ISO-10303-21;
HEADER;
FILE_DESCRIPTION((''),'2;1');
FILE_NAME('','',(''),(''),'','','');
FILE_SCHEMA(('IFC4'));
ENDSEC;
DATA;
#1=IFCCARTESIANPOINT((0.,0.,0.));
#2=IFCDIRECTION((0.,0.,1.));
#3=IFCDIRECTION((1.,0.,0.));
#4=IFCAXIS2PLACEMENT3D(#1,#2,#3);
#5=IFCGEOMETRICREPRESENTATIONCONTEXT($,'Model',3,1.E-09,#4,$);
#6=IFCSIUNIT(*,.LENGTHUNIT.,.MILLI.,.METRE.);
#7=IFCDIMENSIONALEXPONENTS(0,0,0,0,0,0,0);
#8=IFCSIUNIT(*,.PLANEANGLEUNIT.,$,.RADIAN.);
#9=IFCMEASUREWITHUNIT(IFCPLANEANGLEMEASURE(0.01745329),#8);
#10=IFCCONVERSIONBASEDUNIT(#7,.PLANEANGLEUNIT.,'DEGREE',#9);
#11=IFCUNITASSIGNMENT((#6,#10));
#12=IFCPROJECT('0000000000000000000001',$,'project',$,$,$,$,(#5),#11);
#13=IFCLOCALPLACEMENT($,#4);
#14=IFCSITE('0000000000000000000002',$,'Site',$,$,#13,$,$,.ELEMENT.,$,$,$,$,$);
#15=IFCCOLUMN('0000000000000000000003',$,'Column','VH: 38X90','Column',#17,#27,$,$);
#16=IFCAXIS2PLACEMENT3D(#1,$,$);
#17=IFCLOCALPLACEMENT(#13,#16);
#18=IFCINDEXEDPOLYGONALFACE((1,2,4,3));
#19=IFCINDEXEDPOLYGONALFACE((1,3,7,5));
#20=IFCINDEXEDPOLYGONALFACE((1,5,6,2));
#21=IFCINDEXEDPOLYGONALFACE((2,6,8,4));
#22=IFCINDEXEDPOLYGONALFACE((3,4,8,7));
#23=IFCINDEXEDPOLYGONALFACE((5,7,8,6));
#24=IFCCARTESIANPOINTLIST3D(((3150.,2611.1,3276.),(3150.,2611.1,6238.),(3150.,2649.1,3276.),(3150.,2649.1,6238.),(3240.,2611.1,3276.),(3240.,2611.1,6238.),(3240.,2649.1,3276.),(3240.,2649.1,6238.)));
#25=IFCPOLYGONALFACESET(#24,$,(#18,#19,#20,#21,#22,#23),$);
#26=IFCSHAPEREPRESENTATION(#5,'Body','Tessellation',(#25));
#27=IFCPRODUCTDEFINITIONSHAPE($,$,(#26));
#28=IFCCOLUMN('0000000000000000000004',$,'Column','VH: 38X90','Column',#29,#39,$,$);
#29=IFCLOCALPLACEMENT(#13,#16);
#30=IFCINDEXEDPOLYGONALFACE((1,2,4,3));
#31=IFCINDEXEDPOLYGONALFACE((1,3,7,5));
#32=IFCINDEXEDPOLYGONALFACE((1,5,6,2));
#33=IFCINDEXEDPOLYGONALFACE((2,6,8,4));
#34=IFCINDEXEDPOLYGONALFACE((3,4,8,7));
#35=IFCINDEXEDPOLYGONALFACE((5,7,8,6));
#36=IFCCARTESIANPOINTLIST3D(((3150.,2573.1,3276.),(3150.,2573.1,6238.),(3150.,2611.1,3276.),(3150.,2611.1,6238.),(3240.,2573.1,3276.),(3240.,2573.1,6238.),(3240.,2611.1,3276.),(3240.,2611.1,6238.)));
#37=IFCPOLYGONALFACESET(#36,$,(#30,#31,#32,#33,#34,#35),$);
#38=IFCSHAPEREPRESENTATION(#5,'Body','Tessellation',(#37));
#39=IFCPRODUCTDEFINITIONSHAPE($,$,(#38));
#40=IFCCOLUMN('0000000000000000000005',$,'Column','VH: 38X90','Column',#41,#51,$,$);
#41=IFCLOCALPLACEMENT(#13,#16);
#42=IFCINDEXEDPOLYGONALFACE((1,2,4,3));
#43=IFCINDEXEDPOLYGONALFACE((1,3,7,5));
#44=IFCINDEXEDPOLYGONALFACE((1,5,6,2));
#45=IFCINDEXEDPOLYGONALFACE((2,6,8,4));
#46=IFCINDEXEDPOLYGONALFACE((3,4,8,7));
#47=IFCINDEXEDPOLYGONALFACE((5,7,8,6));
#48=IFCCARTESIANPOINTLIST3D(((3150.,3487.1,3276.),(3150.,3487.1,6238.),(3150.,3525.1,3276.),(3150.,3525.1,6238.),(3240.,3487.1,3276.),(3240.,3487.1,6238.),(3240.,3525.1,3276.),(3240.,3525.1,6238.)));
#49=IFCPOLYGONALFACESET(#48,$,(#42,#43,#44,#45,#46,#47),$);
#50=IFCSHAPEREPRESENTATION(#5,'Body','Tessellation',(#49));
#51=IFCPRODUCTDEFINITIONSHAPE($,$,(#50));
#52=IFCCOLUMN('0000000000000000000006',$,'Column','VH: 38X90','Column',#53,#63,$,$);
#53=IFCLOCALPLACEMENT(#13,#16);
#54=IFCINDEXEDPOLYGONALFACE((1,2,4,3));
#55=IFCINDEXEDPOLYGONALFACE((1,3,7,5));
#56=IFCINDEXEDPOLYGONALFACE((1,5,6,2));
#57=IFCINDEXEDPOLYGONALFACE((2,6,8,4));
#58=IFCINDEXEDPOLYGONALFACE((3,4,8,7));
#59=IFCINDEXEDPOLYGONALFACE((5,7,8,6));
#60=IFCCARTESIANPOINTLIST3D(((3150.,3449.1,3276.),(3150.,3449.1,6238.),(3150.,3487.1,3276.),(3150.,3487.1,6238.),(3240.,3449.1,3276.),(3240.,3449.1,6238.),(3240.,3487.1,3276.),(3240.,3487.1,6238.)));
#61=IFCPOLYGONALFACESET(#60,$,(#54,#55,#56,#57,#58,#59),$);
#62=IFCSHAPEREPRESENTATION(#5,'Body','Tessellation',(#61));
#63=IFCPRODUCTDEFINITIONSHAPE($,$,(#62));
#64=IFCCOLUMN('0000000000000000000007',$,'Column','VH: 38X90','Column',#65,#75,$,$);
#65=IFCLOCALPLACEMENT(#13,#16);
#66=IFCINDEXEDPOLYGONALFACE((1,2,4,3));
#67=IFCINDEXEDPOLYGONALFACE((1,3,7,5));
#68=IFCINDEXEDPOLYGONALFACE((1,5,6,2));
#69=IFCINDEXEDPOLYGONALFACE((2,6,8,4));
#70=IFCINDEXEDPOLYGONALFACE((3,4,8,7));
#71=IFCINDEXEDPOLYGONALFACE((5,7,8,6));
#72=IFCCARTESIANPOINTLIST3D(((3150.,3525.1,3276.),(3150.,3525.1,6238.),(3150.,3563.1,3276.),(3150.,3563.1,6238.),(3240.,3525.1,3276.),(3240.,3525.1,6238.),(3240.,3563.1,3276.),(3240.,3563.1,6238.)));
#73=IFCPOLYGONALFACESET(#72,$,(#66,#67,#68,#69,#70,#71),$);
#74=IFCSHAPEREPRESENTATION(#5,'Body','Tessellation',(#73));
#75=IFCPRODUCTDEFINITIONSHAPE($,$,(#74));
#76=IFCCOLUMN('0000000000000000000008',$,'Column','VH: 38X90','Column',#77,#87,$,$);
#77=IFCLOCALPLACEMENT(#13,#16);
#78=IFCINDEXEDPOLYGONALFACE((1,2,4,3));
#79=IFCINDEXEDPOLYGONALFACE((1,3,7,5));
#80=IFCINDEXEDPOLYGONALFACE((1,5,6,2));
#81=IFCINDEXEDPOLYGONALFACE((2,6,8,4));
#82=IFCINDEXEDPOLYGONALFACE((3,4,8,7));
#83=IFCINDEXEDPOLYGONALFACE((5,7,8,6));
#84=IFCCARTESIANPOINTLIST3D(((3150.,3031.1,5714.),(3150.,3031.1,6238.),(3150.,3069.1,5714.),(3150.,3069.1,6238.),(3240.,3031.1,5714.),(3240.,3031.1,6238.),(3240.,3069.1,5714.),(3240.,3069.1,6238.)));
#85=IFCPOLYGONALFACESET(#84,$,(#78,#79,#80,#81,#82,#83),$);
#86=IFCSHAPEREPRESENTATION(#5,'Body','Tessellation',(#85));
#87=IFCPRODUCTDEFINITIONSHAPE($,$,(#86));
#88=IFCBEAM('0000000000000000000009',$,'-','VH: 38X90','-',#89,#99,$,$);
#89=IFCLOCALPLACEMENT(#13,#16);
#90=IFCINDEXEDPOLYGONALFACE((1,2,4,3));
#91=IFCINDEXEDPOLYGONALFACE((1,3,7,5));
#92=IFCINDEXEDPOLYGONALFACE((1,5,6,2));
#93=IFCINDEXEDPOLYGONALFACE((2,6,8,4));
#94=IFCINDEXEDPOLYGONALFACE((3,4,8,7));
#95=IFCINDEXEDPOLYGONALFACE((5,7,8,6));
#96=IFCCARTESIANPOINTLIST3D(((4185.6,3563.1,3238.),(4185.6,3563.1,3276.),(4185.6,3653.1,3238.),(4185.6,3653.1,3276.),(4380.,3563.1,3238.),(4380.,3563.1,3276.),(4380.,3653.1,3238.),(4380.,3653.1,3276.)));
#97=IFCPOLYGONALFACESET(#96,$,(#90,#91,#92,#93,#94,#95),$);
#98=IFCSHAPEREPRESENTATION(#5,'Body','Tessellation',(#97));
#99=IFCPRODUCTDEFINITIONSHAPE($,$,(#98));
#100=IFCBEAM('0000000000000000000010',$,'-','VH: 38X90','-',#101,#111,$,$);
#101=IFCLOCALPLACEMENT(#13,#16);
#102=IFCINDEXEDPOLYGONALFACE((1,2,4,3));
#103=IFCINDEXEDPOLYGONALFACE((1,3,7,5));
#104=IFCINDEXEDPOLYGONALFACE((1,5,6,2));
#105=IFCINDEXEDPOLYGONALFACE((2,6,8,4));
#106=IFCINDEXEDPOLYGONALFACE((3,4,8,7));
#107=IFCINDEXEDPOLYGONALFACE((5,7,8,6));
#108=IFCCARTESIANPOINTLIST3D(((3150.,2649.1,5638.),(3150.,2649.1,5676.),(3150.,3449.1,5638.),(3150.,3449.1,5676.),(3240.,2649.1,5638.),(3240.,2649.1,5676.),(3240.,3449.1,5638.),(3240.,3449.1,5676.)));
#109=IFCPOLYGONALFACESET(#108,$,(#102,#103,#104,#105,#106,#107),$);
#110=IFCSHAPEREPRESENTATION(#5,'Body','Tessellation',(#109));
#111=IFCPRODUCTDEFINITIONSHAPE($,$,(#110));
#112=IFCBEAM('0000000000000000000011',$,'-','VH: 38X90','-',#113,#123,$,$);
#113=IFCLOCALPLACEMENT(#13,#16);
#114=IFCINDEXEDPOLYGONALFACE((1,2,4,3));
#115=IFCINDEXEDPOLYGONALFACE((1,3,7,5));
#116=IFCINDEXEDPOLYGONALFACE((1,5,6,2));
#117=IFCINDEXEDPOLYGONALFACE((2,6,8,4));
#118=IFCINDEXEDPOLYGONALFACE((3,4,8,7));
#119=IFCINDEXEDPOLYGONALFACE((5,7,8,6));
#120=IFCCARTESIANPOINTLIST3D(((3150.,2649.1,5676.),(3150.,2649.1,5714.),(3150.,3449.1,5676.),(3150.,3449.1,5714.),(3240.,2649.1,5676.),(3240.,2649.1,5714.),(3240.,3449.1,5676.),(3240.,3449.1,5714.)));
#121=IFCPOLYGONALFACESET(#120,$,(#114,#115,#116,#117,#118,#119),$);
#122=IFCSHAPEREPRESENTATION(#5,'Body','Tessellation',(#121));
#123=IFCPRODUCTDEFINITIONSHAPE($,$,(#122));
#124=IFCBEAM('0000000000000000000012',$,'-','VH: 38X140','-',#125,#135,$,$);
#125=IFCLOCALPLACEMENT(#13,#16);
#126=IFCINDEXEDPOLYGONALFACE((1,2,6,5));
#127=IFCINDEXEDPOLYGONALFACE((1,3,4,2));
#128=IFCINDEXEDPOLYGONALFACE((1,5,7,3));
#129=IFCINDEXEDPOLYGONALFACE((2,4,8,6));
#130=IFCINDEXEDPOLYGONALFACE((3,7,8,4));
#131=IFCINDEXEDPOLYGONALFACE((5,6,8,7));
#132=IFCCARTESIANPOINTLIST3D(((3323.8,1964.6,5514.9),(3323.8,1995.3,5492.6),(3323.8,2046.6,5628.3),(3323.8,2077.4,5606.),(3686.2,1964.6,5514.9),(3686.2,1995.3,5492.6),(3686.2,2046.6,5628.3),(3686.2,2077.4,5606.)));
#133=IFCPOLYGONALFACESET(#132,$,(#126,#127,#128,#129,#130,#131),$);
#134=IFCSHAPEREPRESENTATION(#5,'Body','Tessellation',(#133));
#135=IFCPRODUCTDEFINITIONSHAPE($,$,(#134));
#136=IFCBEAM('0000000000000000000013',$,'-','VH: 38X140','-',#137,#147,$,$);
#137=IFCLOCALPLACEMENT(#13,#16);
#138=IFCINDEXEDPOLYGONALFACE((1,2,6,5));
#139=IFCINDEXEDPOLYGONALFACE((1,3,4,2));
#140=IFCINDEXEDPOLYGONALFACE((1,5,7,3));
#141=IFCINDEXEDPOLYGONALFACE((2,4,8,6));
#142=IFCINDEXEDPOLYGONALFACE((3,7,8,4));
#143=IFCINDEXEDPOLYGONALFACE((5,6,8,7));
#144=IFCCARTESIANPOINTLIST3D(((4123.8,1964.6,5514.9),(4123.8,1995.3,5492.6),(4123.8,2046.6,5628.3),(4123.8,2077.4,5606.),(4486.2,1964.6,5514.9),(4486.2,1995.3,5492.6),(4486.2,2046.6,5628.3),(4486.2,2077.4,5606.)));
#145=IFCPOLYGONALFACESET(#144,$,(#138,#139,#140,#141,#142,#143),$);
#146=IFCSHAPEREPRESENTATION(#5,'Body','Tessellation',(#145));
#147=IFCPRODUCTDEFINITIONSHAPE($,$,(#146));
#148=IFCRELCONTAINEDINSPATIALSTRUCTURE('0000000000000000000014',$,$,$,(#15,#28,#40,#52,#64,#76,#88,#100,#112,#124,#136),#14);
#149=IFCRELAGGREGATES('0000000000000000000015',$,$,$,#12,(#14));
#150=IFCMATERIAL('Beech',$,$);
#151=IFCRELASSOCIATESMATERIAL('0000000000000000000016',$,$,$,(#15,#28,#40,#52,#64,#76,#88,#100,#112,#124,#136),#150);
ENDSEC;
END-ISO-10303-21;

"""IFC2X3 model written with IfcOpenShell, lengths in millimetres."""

from ifc_helpers import new_model, entity, si_unit, converted_unit, frame, origin, origin_with_axes, origin_2d, place, context, project, spatial, rectangle, extrude, material, element, save


model = new_model("IFC2X3")

# Units and contexts
model_context = context("Model", 3, precision=1e-09, world=origin_with_axes())
ifc_project = project(units=[si_unit("LENGTHUNIT", "METRE", prefix="MILLI"), converted_unit("PLANEANGLEUNIT", "DEGREE", entity("IfcPlaneAngleMeasure", 0.01745329), si_unit("PLANEANGLEUNIT", "RADIAN"), dimensions=[0, 0, 0, 0, 0, 0, 0])], contexts=[model_context])

# Site
site_placement = place(None, origin_with_axes())
site = spatial("IfcSite", under=ifc_project, at=site_placement, Name="Site", CompositionType="ELEMENT")

# Columns
ifc_material = material(Name="Beech")
for number, where, z_axis, x_axis, name in (
    (1, (3195.0, 2630.1, 3276.0), (0.0, 0.0, -1.0), (0.0, -1.0, 0.0), "Column"),
    (2, (3195.0, 2592.1, 3276.0), (0.0, 0.0, -1.0), (0.0, -1.0, 0.0), "Column"),
    (3, (3195.0, 3506.1, 3276.0), (0.0, 0.0, -1.0), (0.0, -1.0, 0.0), "Column"),
    (4, (3195.0, 3468.1, 3276.0), (0.0, 0.0, -1.0), (0.0, -1.0, 0.0), "Column"),
    (5, (3195.0, 3544.1, 3276.0), (0.0, 0.0, -1.0), (0.0, -1.0, 0.0), "Column"),
):
    element("IfcColumn", number, at=place(None, frame(where, z_axis=z_axis, x_axis=x_axis)), inside=site, material=ifc_material, Name=name, Description="VH: 38X90", ObjectType="Column", context=model_context, shape_type="SweptSolid", body=[
        extrude(rectangle(XDim=38.0, YDim=90.0, at=origin_2d()), origin(), (0.0, 0.0, -1.0), 2962.0),
    ])
column_1_placement = place(None, frame((3195.0, 3050.1, 5714.0), z_axis=(0.0, 0.0, -1.0), x_axis=(0.0, -1.0, 0.0)))
element("IfcColumn", 6, at=column_1_placement, inside=site, material=ifc_material, Name="Column", Description="VH: 38X90", ObjectType="Column", context=model_context, shape_type="SweptSolid", body=[
    extrude(rectangle(XDim=38.0, YDim=90.0, at=origin_2d()), origin(), (0.0, 0.0, -1.0), 524.0),
])

# Beams
beam_placement = place(None, frame((4380.0, 3608.1, 3257.0), z_axis=(1.0, 0.0, 0.0), x_axis=(0.0, 0.0, -1.0)))
element("IfcBeam", 7, at=beam_placement, inside=site, material=ifc_material, Name="-", Description="VH: 38X90", ObjectType="-", context=model_context, shape_type="SweptSolid", body=[
    extrude(rectangle(XDim=38.0, YDim=90.0, at=origin_2d()), origin(), (0.0, 0.0, -1.0), 194.4),
])
for number, where, z_axis, x_axis, name in (
    (8, (3195.0, 2649.1, 5657.0), (0.0, -1.0, 0.0), (0.0, 0.0, -1.0), "-"),
    (9, (3195.0, 2649.1, 5695.0), (0.0, -1.0, 0.0), (0.0, 0.0, -1.0), "-"),
):
    element("IfcBeam", number, at=place(None, frame(where, z_axis=z_axis, x_axis=x_axis)), inside=site, material=ifc_material, Name=name, Description="VH: 38X90", ObjectType="-", context=model_context, shape_type="SweptSolid", body=[
        extrude(rectangle(XDim=38.0, YDim=90.0, at=origin_2d()), origin(), (0.0, 0.0, -1.0), 800.0),
    ])

# Beams
for number, where, z_axis, x_axis, name in (
    (10, (3323.8, 2021.0, 5560.4), (-1.0, 0.000006, -0.000004), (0.000007, 0.810145, -0.58623), "-"),
    (11, (4123.8, 2021.0, 5560.4), (-1.0, 0.000006, -0.000004), (0.000007, 0.810145, -0.58623), "-"),
):
    element("IfcBeam", number, at=place(None, frame(where, z_axis=z_axis, x_axis=x_axis)), inside=site, material=ifc_material, Name=name, Description="VH: 38X140", ObjectType="-", context=model_context, shape_type="SweptSolid", body=[
        extrude(rectangle(XDim=38.0, YDim=140.0, at=origin_2d()), origin(), (0.0, 0.0, -1.0), 362.5),
    ])

save(model, "model.ifc")
